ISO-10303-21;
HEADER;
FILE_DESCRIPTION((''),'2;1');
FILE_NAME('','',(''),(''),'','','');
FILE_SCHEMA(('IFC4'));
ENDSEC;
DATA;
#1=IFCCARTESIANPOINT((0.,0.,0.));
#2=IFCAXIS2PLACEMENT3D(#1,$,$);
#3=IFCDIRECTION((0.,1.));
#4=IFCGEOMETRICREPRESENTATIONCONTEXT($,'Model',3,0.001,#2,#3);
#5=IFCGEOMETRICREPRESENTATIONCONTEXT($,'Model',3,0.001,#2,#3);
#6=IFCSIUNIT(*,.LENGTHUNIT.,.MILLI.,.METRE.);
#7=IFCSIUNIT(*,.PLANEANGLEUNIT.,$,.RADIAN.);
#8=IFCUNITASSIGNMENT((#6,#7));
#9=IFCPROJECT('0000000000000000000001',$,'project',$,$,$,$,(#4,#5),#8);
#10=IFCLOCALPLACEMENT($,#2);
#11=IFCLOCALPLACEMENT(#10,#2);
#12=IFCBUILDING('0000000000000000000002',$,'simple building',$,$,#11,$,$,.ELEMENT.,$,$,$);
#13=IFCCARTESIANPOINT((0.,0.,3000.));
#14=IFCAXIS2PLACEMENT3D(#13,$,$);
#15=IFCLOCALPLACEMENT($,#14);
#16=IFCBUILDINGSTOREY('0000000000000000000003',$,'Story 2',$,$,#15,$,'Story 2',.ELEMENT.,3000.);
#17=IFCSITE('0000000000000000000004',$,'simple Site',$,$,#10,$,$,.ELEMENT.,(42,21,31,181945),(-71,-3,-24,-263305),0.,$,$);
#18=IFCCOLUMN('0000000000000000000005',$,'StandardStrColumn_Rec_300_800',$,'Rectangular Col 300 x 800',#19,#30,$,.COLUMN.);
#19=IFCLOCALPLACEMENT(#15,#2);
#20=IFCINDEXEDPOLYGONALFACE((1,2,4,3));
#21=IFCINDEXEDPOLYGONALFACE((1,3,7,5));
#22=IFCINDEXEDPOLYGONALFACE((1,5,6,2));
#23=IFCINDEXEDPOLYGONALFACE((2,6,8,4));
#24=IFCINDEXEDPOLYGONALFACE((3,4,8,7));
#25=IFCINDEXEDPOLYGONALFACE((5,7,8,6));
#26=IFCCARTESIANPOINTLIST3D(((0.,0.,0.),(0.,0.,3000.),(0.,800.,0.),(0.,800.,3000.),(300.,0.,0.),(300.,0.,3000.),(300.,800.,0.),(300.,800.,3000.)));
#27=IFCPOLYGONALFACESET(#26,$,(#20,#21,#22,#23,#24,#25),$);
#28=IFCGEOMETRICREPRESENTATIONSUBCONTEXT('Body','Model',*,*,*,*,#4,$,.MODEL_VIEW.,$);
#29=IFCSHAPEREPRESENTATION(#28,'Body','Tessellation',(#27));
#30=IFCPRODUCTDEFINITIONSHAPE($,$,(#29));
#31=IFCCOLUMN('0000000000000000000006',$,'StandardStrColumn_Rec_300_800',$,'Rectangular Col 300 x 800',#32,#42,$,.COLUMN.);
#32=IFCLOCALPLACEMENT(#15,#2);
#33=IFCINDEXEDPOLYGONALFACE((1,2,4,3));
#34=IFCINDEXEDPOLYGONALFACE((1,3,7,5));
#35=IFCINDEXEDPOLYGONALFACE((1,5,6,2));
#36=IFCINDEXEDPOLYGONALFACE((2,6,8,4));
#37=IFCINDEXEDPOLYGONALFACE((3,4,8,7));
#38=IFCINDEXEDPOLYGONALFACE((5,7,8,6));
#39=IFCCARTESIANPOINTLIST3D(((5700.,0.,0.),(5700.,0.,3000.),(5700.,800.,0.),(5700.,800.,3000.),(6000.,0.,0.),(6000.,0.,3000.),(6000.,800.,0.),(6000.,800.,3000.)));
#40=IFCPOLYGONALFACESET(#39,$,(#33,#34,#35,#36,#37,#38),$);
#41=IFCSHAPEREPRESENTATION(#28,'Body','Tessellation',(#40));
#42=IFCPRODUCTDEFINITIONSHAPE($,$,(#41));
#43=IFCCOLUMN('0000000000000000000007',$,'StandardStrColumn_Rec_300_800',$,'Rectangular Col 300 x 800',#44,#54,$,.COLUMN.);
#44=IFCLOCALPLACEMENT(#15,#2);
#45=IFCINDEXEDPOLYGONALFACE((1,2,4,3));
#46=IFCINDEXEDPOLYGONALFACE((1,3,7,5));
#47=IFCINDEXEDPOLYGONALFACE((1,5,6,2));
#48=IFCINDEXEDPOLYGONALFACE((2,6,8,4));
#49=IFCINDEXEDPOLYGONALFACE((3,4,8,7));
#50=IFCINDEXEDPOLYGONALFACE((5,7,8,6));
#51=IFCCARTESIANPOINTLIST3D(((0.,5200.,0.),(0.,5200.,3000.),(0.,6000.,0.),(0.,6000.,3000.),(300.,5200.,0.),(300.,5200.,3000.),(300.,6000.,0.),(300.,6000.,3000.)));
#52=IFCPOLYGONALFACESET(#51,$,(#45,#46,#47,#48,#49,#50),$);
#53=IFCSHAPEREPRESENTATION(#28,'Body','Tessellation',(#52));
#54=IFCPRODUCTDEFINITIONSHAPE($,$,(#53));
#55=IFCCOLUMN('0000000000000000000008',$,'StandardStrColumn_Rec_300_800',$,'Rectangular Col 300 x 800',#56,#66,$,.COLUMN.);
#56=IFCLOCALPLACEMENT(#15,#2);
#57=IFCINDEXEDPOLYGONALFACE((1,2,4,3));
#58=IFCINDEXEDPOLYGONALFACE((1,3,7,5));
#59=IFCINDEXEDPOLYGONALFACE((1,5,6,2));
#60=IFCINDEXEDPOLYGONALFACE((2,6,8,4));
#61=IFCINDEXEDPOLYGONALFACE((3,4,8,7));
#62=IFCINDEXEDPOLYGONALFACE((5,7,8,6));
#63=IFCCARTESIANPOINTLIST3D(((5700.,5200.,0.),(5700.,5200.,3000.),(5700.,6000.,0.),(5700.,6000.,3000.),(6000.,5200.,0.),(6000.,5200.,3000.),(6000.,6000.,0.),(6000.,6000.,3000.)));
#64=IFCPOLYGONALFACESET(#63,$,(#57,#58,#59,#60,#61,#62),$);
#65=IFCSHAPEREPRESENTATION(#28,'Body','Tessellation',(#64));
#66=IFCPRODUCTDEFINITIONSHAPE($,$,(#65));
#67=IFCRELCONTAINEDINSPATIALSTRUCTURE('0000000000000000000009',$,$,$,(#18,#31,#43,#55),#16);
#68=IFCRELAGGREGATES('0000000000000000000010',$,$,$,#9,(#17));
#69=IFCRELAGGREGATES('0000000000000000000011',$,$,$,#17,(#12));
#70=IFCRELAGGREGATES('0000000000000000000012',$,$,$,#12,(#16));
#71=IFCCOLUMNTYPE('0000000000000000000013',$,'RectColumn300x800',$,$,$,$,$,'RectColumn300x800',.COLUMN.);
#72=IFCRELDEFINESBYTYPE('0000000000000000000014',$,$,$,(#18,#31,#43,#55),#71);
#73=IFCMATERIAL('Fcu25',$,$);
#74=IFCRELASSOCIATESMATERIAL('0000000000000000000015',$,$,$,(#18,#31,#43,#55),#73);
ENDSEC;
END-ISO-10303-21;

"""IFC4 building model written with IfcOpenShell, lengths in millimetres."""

from ifc_helpers import new_model, si_unit, direction, frame, origin, origin_with_axes, origin_2d_with_axis, place, context, subcontext, project, spatial, rectangle, extrude, material, material_profile, profile_set, profile_usage, type_object, element, save


model = new_model("IFC4")

# Units and contexts
model_context_1 = context("Model", 3, precision=0.001, world=origin(), true_north=direction((0.0, 1.0)))
model_context_2 = context("Model", 3, precision=0.001, world=origin(), true_north=direction((0.0, 1.0)))
body_context = subcontext(model_context_1, "Body", "Model", "MODEL_VIEW")
ifc_project = project(units=[si_unit("LENGTHUNIT", "METRE", prefix="MILLI"), si_unit("PLANEANGLEUNIT", "RADIAN")], contexts=[model_context_1, model_context_2])

# Site, building, storey
site_placement = place(None, origin())
site = spatial("IfcSite", under=ifc_project, at=site_placement, Name="simple Site", CompositionType="ELEMENT", RefLatitude=(42, 21, 31, 181945), RefLongitude=(-71, -3, -24, -263305), RefElevation=0.0)
building_placement = place(site_placement, origin())
building = spatial("IfcBuilding", under=site, at=building_placement, Name="simple building", CompositionType="ELEMENT")
storey_placement = place(None, frame((0.0, 0.0, 3000.0)))
storey = spatial("IfcBuildingStorey", under=building, at=storey_placement, Name="Story 2", LongName="Story 2", CompositionType="ELEMENT", Elevation=3000.0)

# Columns
ifc_material = material(Name="Fcu25")
ifc_material_profile = material_profile(ifc_material, rectangle(XDim=300.0, YDim=800.0, at=origin_2d_with_axis()))
ifc_profile_set = profile_set([ifc_material_profile])
ifc_profile_usage_1 = profile_usage(ifc_profile_set, cardinal=7)
column_type = type_object("IfcColumnType", Name="RectColumn300x800", ElementType="RectColumn300x800", PredefinedType="COLUMN")
column_1_placement = place(None, frame((150.0, 400.0, 3000.0), z_axis=(0.0, 0.0, 1.0), x_axis=(1.0, 0.0, 0.0)))
element("IfcColumn", 1, at=column_1_placement, inside=storey, type_object=column_type, material=ifc_profile_usage_1, Name="StandardStrColumn_Rec_300_800", ObjectType="Rectangular Col 300 x 800", PredefinedType="COLUMN", context=body_context, shape_type="SweptSolid", body=[
    extrude(rectangle(XDim=300.0, YDim=800.0, at=origin_2d_with_axis()), origin_with_axes(), (0.0, 0.0, 1.0), 3000.0),
])
ifc_profile_usage_2 = profile_usage(ifc_profile_set, cardinal=9)
column_2_placement = place(None, frame((5850.0, 400.0, 3000.0), z_axis=(0.0, 0.0, 1.0), x_axis=(1.0, 0.0, 0.0)))
element("IfcColumn", 2, at=column_2_placement, inside=storey, type_object=column_type, material=ifc_profile_usage_2, Name="StandardStrColumn_Rec_300_800", ObjectType="Rectangular Col 300 x 800", PredefinedType="COLUMN", context=body_context, shape_type="SweptSolid", body=[
    extrude(rectangle(XDim=300.0, YDim=800.0, at=origin_2d_with_axis()), origin_with_axes(), (0.0, 0.0, 1.0), 3000.0),
])
ifc_profile_usage_3 = profile_usage(ifc_profile_set, cardinal=1)
column_3_placement = place(None, frame((150.0, 5600.0, 3000.0), z_axis=(0.0, 0.0, 1.0), x_axis=(1.0, 0.0, 0.0)))
element("IfcColumn", 3, at=column_3_placement, inside=storey, type_object=column_type, material=ifc_profile_usage_3, Name="StandardStrColumn_Rec_300_800", ObjectType="Rectangular Col 300 x 800", PredefinedType="COLUMN", context=body_context, shape_type="SweptSolid", body=[
    extrude(rectangle(XDim=300.0, YDim=800.0, at=origin_2d_with_axis()), origin_with_axes(), (0.0, 0.0, 1.0), 3000.0),
])
ifc_profile_usage_4 = profile_usage(ifc_profile_set, cardinal=3)
column_4_placement = place(None, frame((5850.0, 5600.0, 3000.0), z_axis=(0.0, 0.0, 1.0), x_axis=(1.0, 0.0, 0.0)))
element("IfcColumn", 4, at=column_4_placement, inside=storey, type_object=column_type, material=ifc_profile_usage_4, Name="StandardStrColumn_Rec_300_800", ObjectType="Rectangular Col 300 x 800", PredefinedType="COLUMN", context=body_context, shape_type="SweptSolid", body=[
    extrude(rectangle(XDim=300.0, YDim=800.0, at=origin_2d_with_axis()), origin_with_axes(), (0.0, 0.0, 1.0), 3000.0),
])

save(model, "model.ifc")
